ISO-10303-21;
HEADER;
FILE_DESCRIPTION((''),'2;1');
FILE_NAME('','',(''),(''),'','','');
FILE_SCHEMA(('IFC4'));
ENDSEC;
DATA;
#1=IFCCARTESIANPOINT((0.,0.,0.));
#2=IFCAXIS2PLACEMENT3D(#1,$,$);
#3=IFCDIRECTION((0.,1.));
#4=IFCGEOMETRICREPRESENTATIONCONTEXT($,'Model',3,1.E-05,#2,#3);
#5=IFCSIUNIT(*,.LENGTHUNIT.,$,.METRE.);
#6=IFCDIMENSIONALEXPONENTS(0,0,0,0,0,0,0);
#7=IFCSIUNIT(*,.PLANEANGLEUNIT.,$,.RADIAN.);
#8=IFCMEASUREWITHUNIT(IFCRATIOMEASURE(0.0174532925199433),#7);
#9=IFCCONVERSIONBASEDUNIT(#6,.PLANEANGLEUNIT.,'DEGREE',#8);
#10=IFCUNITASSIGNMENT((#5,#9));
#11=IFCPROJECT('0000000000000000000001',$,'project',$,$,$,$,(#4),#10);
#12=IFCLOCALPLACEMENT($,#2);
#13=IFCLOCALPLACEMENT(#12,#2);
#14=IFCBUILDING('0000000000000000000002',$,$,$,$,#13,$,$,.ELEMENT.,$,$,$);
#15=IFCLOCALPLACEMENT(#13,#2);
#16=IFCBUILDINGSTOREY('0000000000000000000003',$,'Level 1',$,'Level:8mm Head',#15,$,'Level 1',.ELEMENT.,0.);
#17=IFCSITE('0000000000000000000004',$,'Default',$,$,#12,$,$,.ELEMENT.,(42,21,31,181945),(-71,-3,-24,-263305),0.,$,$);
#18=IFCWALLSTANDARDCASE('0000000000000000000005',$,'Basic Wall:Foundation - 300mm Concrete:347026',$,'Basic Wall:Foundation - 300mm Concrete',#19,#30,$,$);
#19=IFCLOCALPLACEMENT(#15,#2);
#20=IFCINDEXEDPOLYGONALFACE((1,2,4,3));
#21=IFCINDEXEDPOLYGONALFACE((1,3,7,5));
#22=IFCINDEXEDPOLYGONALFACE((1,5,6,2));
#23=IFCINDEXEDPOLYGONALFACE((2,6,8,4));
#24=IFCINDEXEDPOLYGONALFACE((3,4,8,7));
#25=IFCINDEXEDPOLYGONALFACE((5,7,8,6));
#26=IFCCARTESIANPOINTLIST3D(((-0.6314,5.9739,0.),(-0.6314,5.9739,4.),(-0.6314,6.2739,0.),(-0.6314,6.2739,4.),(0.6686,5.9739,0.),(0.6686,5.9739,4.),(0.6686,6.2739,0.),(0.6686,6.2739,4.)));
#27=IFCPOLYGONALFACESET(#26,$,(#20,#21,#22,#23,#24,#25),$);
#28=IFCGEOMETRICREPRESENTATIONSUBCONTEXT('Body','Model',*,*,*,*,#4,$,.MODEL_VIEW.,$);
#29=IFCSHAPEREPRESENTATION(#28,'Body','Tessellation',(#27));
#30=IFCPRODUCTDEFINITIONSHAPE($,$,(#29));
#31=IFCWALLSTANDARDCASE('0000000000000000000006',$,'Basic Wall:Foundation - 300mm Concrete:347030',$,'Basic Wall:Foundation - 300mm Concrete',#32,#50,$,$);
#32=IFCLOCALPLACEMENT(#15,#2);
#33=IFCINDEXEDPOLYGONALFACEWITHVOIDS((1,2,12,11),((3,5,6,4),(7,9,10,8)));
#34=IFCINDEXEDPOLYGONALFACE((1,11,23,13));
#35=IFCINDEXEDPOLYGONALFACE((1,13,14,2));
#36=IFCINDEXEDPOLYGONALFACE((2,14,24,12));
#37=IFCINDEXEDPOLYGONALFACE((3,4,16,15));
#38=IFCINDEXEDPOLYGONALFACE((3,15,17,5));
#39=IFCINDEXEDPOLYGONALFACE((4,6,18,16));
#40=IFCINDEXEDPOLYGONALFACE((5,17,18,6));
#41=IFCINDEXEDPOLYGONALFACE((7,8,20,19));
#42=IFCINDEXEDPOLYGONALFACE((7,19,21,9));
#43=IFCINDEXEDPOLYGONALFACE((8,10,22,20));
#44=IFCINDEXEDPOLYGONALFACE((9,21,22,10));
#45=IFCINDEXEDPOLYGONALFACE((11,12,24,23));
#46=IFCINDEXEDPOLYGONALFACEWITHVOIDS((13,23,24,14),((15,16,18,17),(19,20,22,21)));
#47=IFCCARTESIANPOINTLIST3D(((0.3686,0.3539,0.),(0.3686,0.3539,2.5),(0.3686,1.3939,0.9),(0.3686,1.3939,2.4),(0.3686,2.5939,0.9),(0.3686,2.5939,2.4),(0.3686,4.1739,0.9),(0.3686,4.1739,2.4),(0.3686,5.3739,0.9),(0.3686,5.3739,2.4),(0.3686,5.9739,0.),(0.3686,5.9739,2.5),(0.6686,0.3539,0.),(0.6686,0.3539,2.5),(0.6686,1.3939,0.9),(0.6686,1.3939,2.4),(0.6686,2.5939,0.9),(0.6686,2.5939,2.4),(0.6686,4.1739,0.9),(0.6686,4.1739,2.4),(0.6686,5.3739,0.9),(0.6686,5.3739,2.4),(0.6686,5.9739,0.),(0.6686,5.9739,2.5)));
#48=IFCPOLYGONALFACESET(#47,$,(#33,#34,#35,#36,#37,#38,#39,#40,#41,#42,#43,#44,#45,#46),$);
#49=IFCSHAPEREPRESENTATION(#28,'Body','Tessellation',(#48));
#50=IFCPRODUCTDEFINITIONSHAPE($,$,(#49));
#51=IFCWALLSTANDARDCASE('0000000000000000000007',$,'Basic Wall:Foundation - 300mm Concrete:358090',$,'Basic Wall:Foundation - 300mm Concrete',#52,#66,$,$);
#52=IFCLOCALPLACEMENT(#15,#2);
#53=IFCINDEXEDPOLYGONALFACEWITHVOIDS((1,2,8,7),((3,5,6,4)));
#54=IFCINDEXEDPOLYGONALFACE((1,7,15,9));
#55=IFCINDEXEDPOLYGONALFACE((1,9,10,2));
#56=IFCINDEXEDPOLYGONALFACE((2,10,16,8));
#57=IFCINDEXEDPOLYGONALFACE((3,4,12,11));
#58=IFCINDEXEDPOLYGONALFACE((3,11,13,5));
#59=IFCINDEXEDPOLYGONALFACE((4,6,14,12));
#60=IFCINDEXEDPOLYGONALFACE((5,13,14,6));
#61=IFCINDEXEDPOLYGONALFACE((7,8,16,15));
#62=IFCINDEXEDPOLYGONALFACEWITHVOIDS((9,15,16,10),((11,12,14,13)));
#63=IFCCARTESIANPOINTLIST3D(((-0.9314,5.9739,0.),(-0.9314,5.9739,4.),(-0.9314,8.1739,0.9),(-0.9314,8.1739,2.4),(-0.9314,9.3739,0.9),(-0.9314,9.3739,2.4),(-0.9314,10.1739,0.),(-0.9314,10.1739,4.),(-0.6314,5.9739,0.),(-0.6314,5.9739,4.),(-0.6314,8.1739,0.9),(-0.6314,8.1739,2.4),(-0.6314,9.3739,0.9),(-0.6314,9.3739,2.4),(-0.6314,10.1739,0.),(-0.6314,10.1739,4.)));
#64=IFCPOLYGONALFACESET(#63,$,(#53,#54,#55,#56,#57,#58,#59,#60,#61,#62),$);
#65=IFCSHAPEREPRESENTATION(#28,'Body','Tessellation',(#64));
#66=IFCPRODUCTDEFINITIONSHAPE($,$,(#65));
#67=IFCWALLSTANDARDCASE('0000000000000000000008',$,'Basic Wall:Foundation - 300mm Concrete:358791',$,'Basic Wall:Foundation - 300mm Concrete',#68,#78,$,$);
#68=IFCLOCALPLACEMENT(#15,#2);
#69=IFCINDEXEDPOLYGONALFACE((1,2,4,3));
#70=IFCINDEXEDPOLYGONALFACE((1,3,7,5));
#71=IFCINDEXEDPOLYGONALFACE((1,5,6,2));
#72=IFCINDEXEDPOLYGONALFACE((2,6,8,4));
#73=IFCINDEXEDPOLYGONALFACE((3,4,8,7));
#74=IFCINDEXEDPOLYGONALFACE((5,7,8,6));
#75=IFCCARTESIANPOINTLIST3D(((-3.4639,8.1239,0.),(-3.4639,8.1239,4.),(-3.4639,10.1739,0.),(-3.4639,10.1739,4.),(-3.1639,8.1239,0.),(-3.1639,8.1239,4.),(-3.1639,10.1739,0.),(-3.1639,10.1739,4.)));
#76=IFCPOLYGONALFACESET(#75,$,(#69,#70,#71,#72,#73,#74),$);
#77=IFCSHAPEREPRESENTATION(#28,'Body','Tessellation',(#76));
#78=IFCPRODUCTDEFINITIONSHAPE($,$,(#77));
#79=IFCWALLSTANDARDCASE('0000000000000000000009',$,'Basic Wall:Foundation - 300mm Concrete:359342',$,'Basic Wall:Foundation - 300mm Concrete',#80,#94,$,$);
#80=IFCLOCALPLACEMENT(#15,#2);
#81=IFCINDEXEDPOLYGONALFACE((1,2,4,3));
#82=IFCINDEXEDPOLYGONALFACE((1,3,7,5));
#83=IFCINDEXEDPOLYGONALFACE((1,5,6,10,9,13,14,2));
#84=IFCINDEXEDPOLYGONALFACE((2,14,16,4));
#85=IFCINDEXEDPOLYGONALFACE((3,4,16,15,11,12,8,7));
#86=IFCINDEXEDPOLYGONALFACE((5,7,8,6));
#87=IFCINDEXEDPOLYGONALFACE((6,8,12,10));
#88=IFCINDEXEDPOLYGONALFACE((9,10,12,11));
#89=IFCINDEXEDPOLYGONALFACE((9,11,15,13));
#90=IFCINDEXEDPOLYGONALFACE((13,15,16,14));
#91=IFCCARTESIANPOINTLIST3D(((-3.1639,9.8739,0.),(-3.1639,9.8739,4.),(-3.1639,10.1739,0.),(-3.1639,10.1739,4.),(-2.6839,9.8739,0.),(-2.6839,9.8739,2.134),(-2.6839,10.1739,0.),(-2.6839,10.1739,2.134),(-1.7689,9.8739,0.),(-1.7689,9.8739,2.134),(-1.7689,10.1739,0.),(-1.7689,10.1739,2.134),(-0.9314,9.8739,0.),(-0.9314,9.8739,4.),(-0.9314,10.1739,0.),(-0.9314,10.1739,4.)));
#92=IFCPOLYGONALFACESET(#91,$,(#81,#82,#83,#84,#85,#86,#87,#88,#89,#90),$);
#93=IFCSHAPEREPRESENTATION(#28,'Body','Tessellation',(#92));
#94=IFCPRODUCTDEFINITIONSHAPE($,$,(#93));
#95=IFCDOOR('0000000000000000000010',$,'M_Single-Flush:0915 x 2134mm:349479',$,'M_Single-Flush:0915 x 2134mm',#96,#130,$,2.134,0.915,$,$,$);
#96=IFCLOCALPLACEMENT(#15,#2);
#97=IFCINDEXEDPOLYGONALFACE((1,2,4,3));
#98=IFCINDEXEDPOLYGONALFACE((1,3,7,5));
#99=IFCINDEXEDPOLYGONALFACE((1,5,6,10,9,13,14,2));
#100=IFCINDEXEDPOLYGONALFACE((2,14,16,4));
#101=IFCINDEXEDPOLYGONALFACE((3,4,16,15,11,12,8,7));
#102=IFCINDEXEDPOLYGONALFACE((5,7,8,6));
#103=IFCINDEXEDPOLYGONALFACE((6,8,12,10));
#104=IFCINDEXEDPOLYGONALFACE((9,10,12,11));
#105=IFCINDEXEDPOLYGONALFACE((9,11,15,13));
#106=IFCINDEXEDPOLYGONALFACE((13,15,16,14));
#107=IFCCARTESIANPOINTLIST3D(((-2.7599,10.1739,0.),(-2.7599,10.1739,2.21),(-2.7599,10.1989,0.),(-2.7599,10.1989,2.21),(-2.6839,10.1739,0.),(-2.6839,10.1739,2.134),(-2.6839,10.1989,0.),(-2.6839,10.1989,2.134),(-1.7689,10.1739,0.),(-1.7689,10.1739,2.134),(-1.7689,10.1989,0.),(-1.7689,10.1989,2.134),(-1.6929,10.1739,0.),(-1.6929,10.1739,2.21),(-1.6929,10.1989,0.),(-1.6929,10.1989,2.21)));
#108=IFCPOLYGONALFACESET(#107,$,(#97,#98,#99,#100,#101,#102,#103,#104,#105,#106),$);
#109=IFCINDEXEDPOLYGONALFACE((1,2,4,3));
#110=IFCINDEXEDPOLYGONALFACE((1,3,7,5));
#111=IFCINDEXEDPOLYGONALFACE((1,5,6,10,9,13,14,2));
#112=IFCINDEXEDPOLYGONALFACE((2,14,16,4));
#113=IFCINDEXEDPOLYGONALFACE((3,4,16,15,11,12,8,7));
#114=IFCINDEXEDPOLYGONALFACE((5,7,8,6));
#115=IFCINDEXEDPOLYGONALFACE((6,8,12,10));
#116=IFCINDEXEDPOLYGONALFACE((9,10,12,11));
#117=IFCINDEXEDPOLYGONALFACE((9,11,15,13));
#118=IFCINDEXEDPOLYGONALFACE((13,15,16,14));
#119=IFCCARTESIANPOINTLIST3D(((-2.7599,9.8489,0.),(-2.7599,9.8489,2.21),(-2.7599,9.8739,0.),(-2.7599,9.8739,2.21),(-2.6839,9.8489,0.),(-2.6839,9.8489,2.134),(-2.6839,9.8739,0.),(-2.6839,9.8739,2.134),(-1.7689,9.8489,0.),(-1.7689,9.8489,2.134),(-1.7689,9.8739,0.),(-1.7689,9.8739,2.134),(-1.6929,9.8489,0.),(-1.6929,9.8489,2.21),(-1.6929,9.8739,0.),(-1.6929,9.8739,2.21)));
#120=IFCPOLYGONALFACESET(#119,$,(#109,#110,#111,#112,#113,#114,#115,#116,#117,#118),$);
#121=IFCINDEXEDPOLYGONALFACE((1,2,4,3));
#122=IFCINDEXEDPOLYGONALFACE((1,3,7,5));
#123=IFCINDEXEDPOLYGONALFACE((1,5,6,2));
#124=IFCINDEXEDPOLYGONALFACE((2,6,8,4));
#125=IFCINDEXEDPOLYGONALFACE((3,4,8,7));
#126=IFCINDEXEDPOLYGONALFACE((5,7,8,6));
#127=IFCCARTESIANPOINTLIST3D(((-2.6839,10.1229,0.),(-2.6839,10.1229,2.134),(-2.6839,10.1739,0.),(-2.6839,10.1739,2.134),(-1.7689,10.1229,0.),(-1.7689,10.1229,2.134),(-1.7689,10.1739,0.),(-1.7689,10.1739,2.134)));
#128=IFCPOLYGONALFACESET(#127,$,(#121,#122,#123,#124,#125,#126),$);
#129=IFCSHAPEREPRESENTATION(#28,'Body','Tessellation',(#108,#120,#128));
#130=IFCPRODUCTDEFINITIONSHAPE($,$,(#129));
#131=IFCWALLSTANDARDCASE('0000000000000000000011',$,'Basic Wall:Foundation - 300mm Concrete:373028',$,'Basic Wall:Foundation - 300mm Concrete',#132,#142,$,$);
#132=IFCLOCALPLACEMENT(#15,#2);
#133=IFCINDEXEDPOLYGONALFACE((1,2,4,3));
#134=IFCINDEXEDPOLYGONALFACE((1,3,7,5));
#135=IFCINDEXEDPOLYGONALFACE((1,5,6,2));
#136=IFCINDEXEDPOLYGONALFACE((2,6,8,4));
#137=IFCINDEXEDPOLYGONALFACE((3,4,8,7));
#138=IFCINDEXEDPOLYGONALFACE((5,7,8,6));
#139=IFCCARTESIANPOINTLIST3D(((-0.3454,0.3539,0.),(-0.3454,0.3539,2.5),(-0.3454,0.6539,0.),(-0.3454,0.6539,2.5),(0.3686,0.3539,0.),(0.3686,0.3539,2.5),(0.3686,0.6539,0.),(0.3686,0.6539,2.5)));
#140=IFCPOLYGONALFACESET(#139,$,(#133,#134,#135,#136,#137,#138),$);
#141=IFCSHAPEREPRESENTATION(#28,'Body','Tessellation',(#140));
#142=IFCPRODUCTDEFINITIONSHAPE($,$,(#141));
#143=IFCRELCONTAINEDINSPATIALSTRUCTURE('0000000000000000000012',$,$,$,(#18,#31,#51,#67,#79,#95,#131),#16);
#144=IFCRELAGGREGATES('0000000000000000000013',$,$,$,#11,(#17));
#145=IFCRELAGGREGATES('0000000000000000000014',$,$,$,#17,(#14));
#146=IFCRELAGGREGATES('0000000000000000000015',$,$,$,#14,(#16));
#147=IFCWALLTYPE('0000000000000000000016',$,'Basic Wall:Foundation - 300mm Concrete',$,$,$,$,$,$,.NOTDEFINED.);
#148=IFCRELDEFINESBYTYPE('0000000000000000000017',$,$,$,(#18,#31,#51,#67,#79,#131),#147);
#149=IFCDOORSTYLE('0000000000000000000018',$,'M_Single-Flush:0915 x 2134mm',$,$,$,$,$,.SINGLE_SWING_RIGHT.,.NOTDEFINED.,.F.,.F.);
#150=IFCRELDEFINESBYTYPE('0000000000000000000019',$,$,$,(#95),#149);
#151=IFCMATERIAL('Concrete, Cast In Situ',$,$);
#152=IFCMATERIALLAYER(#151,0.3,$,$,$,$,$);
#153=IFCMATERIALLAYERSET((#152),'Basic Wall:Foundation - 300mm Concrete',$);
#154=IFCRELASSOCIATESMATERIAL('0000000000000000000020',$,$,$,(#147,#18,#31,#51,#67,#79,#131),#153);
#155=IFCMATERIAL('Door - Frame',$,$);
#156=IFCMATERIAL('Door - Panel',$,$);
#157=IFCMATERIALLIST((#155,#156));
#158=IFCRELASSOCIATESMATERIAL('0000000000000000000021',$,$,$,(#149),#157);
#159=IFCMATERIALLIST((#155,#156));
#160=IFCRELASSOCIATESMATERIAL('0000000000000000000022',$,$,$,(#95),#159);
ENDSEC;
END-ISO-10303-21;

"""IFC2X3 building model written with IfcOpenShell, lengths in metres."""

from ifc_helpers import new_model, entity, si_unit, converted_unit, direction, frame, frame_2d, origin, place, context, subcontext, project, spatial, polyline, rectangle, outline, extrude, source, transform, mapped, material, material_list, layer, layer_set, layer_usage, type_object, type_shapes, element, fill, save


model = new_model("IFC2X3")

# Units and contexts
model_context = context("Model", 3, precision=1e-05, world=origin(), true_north=direction((0.0, 1.0)))
body_context = subcontext(model_context, "Body", "Model", "MODEL_VIEW")
ifc_project = project(units=[si_unit("LENGTHUNIT", "METRE"), converted_unit("PLANEANGLEUNIT", "DEGREE", entity("IfcRatioMeasure", 0.0174532925199433), si_unit("PLANEANGLEUNIT", "RADIAN"), dimensions=[0, 0, 0, 0, 0, 0, 0])], contexts=[model_context])

# Site, building, storey
site_placement = place(None, origin())
site = spatial("IfcSite", under=ifc_project, at=site_placement, Name="Default", CompositionType="ELEMENT", RefLatitude=(42, 21, 31, 181945), RefLongitude=(-71, -3, -24, -263305), RefElevation=0.0)
building_placement = place(site_placement, origin())
building = spatial("IfcBuilding", under=site, at=building_placement, CompositionType="ELEMENT")
storey_placement = place(building_placement, origin())
storey = spatial("IfcBuildingStorey", under=building, at=storey_placement, Name="Level 1", ObjectType="Level:8mm Head", LongName="Level 1", CompositionType="ELEMENT", Elevation=0.0)

# Wall
ifc_material_1 = material(Name="Concrete, Cast In Situ")
ifc_layer = layer(ifc_material_1, 0.3)
ifc_layer_set = layer_set([ifc_layer], Name="Basic Wall:Foundation - 300mm Concrete")
ifc_layer_usage_1 = layer_usage(ifc_layer_set, "AXIS2", "NEGATIVE", 0.15)
wall_type = type_object("IfcWallType", Name="Basic Wall:Foundation - 300mm Concrete", PredefinedType="NOTDEFINED", material=ifc_layer_set)
wall_1_placement = place(storey_placement, frame((-0.6314, 6.1239, 0.0)))
element("IfcWallStandardCase", 1, at=wall_1_placement, inside=storey, type_object=wall_type, material=ifc_layer_usage_1, Name="Basic Wall:Foundation - 300mm Concrete:347026", ObjectType="Basic Wall:Foundation - 300mm Concrete", context=body_context, shape_type="SweptSolid", body=[
    extrude(rectangle(XDim=1.3, YDim=0.3, at=frame_2d((0.65, 0.0), x_axis=(-1.0, 0.0))), origin(), (0.0, 0.0, 1.0), 4.0),
])

# Wall, openings
ifc_layer_usage_2 = layer_usage(ifc_layer_set, "AXIS2", "NEGATIVE", 0.15)
wall_2_placement = place(storey_placement, frame((0.5186, 5.9739, 0.0), z_axis=(0.0, 0.0, 1.0), x_axis=(0.0, -1.0, 0.0)))
wall_2 = element("IfcWallStandardCase", 2, at=wall_2_placement, inside=storey, type_object=wall_type, material=ifc_layer_usage_2, Name="Basic Wall:Foundation - 300mm Concrete:347030", ObjectType="Basic Wall:Foundation - 300mm Concrete", context=body_context, shape_type="SweptSolid", body=[
    extrude(rectangle(XDim=5.62, YDim=0.3, at=frame_2d((2.81, 0.0), x_axis=(-1.0, 0.0))), origin(), (0.0, 0.0, 1.0), 2.5),
])
opening_1_placement = place(wall_2_placement, frame((0.6, -0.15, 0.9)))
element("IfcOpeningElement", 3, at=opening_1_placement, cuts=wall_2, ObjectType="Opening", context=body_context, shape_type="SweptSolid", body=[
    extrude(rectangle(XDim=1.5, YDim=1.2, at=frame_2d((0.75, 0.6), x_axis=(-1.0, 0.0))), frame((0.0, 0.0, 0.0), z_axis=(0.0, 1.0, 0.0), x_axis=(0.0, 0.0, 1.0)), (0.0, 0.0, 1.0), 0.3),
])
opening_2_placement = place(wall_2_placement, frame((3.38, -0.15, 0.9)))
element("IfcOpeningElement", 4, at=opening_2_placement, cuts=wall_2, ObjectType="Opening", context=body_context, shape_type="SweptSolid", body=[
    extrude(rectangle(XDim=1.5, YDim=1.2, at=frame_2d((0.75, 0.6), x_axis=(-1.0, 0.0))), frame((0.0, 0.0, 0.0), z_axis=(0.0, 1.0, 0.0), x_axis=(0.0, 0.0, 1.0)), (0.0, 0.0, 1.0), 0.3),
])

# Wall, opening
ifc_layer_usage_3 = layer_usage(ifc_layer_set, "AXIS2", "NEGATIVE", 0.15)
wall_3_placement = place(storey_placement, frame((-0.7814, 10.1739, 0.0), z_axis=(0.0, 0.0, 1.0), x_axis=(0.0, -1.0, 0.0)))
wall_3 = element("IfcWallStandardCase", 5, at=wall_3_placement, inside=storey, type_object=wall_type, material=ifc_layer_usage_3, Name="Basic Wall:Foundation - 300mm Concrete:358090", ObjectType="Basic Wall:Foundation - 300mm Concrete", context=body_context, shape_type="SweptSolid", body=[
    extrude(rectangle(XDim=4.2, YDim=0.3, at=frame_2d((2.1, 0.0), x_axis=(-1.0, 0.0))), origin(), (0.0, 0.0, 1.0), 4.0),
])
opening_3_placement = place(wall_3_placement, frame((0.8, -0.15, 0.9)))
element("IfcOpeningElement", 6, at=opening_3_placement, cuts=wall_3, ObjectType="Opening", context=body_context, shape_type="SweptSolid", body=[
    extrude(rectangle(XDim=1.5, YDim=1.2, at=frame_2d((0.75, 0.6), x_axis=(-1.0, 0.0))), frame((0.0, 0.0, 0.0), z_axis=(0.0, 1.0, 0.0), x_axis=(0.0, 0.0, 1.0)), (0.0, 0.0, 1.0), 0.3),
])

# Wall
ifc_layer_usage_4 = layer_usage(ifc_layer_set, "AXIS2", "POSITIVE", -0.15)
wall_4_placement = place(storey_placement, frame((-3.3139, 10.1739, 0.0), z_axis=(0.0, 0.0, 1.0), x_axis=(0.0, -1.0, 0.0)))
element("IfcWallStandardCase", 7, at=wall_4_placement, inside=storey, type_object=wall_type, material=ifc_layer_usage_4, Name="Basic Wall:Foundation - 300mm Concrete:358791", ObjectType="Basic Wall:Foundation - 300mm Concrete", context=body_context, shape_type="SweptSolid", body=[
    extrude(rectangle(XDim=2.05, YDim=0.3, at=frame_2d((1.025, 0.0), x_axis=(-1.0, 0.0))), origin(), (0.0, 0.0, 1.0), 4.0),
])

# Wall, opening, door
ifc_layer_usage_5 = layer_usage(ifc_layer_set, "AXIS2", "NEGATIVE", 0.15)
wall_5_placement = place(storey_placement, frame((-3.1639, 10.0239, 0.0)))
wall_5 = element("IfcWallStandardCase", 8, at=wall_5_placement, inside=storey, type_object=wall_type, material=ifc_layer_usage_5, Name="Basic Wall:Foundation - 300mm Concrete:359342", ObjectType="Basic Wall:Foundation - 300mm Concrete", context=body_context, shape_type="SweptSolid", body=[
    extrude(rectangle(XDim=2.2325, YDim=0.3, at=frame_2d((1.1162, 0.0), x_axis=(-1.0, 0.0))), origin(), (0.0, 0.0, 1.0), 4.0),
])
opening_4_placement = place(wall_5_placement, frame((0.48, -0.15, 0.0)))
opening_4 = element("IfcOpeningElement", 9, at=opening_4_placement, cuts=wall_5, ObjectType="Opening", context=body_context, shape_type="SweptSolid", body=[
    extrude(rectangle(XDim=0.915, YDim=2.134, at=frame_2d((1.067, 0.4575), x_axis=(0.0, 1.0))), frame((0.0, 0.0, 0.0), z_axis=(0.0, 1.0, 0.0), x_axis=(0.0, 0.0, 1.0)), (0.0, 0.0, 1.0), 0.3),
])
ifc_material_2 = material(Name="Door - Frame")
ifc_material_3 = material(Name="Door - Panel")
ifc_material_list_1 = material_list([ifc_material_2, ifc_material_3])
ifc_material_list_2 = material_list([ifc_material_2, ifc_material_3])
door_style = type_object("IfcDoorStyle", Name="M_Single-Flush:0915 x 2134mm", ConstructionType="NOTDEFINED", OperationType="SINGLE_SWING_RIGHT", ParameterTakesPrecedence=False, Sizeable=False, material=ifc_material_list_2)
shared_shape_1 = source(origin(), body_context, "Body", "SweptSolid", [
    extrude(outline(polyline([(-0.5335, -1.124), (0.5335, -1.124), (0.5335, 1.086), (0.4575, 1.086), (0.4575, -1.048), (-0.4575, -1.048), (-0.4575, 1.086), (-0.5335, 1.086), (-0.5335, -1.124)])), frame((0.4575, 0.3, 1.086), z_axis=(0.0, 1.0, 0.0), x_axis=(1.0, 0.0, 0.0)), (0.0, 0.0, 1.0), 0.025),
    extrude(outline(polyline([(-1.124, -0.5335), (1.086, -0.5335), (1.086, -0.4575), (-1.048, -0.4575), (-1.048, 0.4575), (1.086, 0.4575), (1.086, 0.5335), (-1.124, 0.5335), (-1.124, -0.5335)])), frame((0.4575, -0.025, 1.086), z_axis=(0.0, 1.0, 0.0), x_axis=(0.0, 0.0, -1.0)), (0.0, 0.0, 1.0), 0.025),
    extrude(rectangle(XDim=0.051, YDim=0.915, at=frame_2d((0.0, 0.0), x_axis=(1.0, 0.0))), frame((0.4575, 0.2745, 0.0), z_axis=(0.0, 0.0, 1.0), x_axis=(0.0, 1.0, 0.0)), (0.0, 0.0, 1.0), 2.134),
])
type_shapes(door_style, [shared_shape_1])
door_placement = place(opening_4_placement, origin())
door = element("IfcDoor", 10, at=door_placement, inside=storey, type_object=door_style, material=ifc_material_list_1, Name="M_Single-Flush:0915 x 2134mm:349479", ObjectType="M_Single-Flush:0915 x 2134mm", OverallHeight=2.134, OverallWidth=0.915, context=body_context, shape_type="MappedRepresentation", body=[
    mapped(shared_shape_1, transform((0.0, 0.0, 0.0), scale=1.0)),
])
fill(opening_4, door)

# Wall
ifc_layer_usage_6 = layer_usage(ifc_layer_set, "AXIS2", "NEGATIVE", 0.15)
wall_6_placement = place(storey_placement, frame((0.3686, 0.5039, 0.0), z_axis=(0.0, 0.0, 1.0), x_axis=(-1.0, 0.0, 0.0)))
element("IfcWallStandardCase", 11, at=wall_6_placement, inside=storey, type_object=wall_type, material=ifc_layer_usage_6, Name="Basic Wall:Foundation - 300mm Concrete:373028", ObjectType="Basic Wall:Foundation - 300mm Concrete", context=body_context, shape_type="SweptSolid", body=[
    extrude(rectangle(XDim=0.7141, YDim=0.3, at=frame_2d((0.357, 0.0), x_axis=(-1.0, 0.0))), origin(), (0.0, 0.0, 1.0), 2.5),
])

save(model, "model.ifc")
